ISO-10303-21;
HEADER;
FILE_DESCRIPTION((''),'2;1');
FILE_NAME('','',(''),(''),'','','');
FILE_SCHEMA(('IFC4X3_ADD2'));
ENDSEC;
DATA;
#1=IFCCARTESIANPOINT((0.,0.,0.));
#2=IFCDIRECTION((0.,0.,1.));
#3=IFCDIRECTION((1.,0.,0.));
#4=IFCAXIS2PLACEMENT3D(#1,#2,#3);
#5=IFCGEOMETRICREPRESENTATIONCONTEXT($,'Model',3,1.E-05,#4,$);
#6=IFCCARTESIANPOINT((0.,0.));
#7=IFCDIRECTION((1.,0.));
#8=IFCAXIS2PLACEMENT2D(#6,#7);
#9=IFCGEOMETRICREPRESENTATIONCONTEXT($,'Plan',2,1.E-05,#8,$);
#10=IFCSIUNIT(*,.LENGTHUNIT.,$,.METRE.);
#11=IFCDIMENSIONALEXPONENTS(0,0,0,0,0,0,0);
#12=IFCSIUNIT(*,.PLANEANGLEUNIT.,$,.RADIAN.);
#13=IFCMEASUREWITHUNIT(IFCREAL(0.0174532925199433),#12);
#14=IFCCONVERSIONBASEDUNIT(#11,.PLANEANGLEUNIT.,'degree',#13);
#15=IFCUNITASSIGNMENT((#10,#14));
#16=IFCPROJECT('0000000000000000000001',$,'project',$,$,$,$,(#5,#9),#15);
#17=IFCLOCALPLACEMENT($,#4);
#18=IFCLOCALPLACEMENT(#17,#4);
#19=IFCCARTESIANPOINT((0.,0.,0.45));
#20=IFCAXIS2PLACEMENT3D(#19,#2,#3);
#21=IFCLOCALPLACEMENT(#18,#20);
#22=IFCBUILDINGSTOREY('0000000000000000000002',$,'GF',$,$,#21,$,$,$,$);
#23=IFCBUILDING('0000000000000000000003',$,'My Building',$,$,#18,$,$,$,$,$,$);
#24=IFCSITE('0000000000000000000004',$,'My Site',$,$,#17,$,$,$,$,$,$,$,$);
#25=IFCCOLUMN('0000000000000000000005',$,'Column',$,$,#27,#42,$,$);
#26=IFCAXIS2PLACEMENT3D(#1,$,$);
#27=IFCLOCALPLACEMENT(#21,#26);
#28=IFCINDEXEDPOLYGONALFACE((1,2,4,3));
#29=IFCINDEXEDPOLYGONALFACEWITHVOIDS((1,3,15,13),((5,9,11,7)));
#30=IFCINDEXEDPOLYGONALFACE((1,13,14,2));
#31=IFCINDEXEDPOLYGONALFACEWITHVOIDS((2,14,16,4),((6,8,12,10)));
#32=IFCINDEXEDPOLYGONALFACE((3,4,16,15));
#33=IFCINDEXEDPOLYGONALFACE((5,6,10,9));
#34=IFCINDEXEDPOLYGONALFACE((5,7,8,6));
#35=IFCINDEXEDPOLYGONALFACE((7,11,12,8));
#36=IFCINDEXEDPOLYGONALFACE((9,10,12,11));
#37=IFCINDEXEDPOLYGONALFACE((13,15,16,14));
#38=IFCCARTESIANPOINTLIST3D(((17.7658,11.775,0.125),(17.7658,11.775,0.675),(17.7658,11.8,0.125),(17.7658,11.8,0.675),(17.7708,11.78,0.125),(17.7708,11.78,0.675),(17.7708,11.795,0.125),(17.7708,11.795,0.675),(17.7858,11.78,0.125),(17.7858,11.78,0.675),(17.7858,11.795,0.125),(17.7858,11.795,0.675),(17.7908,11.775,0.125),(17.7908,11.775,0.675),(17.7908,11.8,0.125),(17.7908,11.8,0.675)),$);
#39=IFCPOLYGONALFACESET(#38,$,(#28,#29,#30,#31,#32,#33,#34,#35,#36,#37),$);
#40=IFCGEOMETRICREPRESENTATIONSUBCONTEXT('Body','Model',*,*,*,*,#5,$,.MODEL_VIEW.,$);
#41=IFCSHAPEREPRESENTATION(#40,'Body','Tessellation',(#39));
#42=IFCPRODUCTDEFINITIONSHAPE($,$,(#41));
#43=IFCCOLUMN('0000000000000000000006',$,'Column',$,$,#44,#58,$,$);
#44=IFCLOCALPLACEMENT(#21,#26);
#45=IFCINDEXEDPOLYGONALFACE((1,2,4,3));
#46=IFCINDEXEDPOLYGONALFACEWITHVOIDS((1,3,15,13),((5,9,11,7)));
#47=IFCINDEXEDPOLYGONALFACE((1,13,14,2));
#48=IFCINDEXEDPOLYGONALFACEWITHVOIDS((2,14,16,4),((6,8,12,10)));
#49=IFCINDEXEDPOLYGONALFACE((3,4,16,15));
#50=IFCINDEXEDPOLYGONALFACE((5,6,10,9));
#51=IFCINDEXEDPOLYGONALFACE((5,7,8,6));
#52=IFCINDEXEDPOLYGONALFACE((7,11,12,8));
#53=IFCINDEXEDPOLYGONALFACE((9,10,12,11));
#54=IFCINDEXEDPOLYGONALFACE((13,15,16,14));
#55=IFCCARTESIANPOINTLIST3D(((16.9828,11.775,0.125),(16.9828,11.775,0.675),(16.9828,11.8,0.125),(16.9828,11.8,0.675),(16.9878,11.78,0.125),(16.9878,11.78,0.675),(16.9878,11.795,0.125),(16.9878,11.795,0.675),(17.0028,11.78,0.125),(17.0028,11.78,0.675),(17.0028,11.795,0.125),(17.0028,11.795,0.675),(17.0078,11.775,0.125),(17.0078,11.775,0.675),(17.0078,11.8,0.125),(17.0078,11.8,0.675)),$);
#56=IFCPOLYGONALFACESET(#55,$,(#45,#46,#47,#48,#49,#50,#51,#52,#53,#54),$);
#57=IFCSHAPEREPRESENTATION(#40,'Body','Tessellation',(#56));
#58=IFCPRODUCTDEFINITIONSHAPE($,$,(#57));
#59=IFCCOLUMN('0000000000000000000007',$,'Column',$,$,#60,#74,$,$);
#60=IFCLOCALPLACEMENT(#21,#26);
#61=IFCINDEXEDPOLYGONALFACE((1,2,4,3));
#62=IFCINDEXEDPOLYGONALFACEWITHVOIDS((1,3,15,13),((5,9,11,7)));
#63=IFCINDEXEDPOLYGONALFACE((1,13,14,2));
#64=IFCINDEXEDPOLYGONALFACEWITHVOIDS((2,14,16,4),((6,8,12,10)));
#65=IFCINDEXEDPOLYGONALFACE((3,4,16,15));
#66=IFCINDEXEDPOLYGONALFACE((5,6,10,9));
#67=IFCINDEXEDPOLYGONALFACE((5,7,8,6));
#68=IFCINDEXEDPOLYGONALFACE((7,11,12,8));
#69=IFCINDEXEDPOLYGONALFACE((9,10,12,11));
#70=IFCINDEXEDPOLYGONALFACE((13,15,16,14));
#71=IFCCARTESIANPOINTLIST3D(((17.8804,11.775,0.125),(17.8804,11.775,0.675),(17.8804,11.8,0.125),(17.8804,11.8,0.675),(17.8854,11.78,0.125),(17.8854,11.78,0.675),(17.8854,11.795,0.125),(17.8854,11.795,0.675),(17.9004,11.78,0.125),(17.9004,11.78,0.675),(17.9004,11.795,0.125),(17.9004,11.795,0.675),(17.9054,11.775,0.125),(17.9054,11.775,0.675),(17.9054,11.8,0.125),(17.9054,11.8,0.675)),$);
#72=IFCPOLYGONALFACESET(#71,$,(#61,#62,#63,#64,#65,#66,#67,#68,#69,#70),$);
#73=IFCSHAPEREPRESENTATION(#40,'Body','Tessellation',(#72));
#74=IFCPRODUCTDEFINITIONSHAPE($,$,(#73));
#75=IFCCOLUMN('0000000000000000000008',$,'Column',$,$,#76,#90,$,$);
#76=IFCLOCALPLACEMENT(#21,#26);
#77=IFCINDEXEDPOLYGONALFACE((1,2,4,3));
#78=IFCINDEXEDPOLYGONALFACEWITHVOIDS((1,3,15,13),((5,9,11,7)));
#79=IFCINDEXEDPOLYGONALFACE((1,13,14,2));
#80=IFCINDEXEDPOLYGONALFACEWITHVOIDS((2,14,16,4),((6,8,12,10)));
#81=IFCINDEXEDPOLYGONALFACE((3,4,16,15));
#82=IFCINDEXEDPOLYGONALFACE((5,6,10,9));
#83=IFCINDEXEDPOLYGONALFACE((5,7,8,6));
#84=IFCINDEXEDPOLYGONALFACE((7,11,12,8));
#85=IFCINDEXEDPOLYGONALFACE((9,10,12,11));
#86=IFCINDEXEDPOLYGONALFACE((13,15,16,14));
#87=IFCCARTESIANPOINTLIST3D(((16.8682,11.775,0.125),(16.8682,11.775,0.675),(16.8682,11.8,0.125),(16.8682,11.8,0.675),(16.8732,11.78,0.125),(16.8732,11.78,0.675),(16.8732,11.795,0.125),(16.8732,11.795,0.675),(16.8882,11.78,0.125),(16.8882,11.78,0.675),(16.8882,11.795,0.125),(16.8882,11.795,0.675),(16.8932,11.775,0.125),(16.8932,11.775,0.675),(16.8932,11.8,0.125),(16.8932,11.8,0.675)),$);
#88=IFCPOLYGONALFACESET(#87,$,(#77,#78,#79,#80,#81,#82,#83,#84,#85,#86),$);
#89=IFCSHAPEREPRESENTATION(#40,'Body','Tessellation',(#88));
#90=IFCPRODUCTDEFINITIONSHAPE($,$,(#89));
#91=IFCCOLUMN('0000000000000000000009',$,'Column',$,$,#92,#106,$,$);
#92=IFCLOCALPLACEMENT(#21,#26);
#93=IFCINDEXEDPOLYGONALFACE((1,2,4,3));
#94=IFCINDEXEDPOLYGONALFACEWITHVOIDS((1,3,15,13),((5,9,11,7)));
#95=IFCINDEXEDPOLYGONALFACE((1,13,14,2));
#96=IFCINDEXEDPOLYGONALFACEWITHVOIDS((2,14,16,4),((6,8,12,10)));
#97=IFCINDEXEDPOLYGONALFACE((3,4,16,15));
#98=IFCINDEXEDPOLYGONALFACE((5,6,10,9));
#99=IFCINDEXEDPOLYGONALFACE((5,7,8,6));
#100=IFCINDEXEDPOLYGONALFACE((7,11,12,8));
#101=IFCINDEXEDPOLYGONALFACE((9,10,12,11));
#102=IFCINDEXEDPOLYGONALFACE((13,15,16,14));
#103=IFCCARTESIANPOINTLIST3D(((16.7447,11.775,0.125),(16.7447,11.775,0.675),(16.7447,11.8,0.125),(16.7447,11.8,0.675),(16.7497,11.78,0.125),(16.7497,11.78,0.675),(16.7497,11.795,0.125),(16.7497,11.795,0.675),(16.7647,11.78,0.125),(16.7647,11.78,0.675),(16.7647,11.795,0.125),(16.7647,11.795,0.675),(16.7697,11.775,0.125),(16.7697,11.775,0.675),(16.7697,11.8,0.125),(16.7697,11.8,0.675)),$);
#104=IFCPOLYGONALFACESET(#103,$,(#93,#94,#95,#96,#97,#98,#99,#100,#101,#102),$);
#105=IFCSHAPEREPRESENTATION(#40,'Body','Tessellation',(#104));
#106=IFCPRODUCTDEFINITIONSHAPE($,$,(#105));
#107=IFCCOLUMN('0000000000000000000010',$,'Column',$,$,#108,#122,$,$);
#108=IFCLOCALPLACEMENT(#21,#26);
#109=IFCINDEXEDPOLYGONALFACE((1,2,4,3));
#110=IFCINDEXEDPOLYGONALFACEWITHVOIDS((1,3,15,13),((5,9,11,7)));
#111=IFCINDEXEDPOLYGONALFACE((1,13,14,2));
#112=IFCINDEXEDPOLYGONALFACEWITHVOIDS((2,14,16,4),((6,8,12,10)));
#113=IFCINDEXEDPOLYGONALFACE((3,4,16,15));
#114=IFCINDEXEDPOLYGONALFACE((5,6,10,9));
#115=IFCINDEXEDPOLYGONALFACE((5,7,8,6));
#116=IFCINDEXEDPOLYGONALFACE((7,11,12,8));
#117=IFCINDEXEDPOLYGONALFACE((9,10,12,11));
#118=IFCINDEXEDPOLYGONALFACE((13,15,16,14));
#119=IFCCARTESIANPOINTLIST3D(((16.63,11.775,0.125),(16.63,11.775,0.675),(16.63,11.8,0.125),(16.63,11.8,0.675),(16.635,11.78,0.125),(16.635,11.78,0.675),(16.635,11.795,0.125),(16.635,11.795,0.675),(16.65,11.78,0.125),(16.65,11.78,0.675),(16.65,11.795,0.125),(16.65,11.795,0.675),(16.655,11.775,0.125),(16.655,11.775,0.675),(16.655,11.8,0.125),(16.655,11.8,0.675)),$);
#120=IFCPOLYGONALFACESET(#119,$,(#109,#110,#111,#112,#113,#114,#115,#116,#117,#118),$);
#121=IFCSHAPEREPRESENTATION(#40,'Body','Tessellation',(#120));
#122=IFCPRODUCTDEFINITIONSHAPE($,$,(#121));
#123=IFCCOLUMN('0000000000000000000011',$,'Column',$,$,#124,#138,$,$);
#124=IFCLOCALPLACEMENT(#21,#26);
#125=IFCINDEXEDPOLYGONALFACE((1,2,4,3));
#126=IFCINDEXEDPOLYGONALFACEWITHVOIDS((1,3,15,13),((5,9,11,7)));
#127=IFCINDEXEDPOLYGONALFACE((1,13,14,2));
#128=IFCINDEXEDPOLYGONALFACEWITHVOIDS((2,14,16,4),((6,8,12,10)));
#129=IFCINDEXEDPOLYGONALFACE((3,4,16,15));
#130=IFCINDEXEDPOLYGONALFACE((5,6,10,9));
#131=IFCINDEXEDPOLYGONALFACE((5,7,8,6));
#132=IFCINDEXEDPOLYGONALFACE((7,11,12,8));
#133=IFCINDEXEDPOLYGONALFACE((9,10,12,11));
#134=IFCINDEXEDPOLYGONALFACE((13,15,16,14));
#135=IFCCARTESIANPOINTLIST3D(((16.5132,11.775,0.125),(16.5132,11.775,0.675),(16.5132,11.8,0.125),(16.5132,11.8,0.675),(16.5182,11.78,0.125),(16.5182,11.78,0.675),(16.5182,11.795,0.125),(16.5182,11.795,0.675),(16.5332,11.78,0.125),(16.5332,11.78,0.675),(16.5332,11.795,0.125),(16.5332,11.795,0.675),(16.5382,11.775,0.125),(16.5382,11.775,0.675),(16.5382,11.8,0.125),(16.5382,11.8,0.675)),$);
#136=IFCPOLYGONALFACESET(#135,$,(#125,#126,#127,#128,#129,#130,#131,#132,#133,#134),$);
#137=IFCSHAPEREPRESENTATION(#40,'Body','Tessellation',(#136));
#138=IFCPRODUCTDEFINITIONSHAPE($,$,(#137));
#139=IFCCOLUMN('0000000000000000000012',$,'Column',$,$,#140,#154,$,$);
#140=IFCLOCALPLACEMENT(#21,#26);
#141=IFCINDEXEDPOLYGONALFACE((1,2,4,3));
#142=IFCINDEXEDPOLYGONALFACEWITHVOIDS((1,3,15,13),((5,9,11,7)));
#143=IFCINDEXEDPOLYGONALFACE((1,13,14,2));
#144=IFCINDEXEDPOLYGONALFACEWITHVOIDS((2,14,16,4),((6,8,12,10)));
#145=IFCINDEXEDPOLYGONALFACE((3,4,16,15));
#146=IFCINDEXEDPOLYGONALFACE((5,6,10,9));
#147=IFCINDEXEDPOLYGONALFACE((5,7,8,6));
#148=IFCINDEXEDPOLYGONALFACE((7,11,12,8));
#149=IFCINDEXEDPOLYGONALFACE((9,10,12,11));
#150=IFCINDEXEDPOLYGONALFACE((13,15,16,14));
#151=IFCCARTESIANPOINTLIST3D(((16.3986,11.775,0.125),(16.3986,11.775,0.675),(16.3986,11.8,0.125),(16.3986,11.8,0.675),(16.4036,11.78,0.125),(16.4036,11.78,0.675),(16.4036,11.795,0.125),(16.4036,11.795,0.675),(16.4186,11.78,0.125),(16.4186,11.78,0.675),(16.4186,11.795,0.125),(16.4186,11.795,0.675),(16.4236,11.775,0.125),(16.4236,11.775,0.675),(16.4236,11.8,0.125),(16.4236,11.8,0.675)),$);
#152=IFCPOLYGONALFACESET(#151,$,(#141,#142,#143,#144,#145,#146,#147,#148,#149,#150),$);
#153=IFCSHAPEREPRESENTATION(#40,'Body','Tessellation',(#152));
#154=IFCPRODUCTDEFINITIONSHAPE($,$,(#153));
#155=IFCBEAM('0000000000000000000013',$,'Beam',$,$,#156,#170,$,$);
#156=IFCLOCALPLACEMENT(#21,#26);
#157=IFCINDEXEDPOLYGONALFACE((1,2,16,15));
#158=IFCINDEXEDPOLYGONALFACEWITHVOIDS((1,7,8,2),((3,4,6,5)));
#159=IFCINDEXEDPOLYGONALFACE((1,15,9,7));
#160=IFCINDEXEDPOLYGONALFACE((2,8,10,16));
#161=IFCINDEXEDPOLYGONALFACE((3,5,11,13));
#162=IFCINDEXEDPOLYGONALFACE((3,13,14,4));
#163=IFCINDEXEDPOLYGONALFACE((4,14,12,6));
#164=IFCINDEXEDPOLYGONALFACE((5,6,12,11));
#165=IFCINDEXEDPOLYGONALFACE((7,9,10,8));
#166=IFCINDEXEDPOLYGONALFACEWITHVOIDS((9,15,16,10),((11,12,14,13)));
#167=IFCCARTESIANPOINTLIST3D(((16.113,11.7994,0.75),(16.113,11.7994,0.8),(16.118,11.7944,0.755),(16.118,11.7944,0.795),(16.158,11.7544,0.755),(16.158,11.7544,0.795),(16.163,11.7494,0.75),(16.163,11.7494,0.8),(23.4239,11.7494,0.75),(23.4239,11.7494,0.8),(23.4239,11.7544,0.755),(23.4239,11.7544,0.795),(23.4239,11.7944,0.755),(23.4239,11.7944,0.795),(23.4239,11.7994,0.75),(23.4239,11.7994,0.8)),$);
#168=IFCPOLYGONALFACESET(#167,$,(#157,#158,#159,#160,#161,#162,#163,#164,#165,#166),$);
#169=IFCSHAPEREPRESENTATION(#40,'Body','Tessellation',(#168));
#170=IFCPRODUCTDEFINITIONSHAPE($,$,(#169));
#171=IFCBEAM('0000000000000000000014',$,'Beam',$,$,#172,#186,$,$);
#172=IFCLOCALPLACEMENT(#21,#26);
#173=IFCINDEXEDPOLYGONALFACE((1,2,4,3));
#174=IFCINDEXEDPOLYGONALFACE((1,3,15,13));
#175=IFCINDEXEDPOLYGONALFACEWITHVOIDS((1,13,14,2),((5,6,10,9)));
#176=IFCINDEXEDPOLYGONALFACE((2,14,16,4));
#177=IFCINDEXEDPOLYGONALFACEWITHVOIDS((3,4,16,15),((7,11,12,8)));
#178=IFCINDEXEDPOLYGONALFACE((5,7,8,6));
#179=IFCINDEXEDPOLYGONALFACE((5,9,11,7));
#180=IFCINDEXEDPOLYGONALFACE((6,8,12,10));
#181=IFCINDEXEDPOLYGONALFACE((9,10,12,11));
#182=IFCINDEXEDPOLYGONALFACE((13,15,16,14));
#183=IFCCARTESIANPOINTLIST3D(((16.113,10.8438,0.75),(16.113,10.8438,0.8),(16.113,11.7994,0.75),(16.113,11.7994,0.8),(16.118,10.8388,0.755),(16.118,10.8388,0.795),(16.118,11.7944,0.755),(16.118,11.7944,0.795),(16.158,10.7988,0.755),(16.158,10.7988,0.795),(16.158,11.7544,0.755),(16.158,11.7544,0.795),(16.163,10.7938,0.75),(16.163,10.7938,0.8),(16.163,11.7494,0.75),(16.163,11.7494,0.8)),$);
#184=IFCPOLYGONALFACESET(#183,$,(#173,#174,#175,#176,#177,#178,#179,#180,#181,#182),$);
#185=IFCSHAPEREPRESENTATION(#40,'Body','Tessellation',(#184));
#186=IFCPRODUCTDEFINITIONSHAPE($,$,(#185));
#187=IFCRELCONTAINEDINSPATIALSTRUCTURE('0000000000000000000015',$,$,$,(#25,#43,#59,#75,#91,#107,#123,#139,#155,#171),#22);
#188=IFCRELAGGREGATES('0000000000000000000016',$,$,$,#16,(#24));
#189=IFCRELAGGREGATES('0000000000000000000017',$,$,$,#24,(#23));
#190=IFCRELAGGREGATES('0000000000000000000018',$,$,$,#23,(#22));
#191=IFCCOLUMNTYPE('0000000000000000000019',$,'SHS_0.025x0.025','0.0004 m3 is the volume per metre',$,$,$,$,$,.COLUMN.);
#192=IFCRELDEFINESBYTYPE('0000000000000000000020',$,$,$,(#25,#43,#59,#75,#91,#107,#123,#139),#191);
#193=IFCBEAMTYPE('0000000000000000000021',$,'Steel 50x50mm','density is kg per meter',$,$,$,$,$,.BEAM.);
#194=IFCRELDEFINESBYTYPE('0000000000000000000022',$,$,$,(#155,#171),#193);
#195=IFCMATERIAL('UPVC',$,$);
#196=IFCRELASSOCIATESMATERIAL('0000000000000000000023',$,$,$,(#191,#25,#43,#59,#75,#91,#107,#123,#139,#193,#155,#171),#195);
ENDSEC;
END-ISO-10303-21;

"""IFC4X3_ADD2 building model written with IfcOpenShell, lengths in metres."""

from ifc_helpers import new_model, entity, si_unit, converted_unit, frame, origin_with_axes, origin_2d_with_axis, place, context, subcontext, project, spatial, hollow_rectangle, extrude, clip, halfspace, material, material_profile, profile_set, profile_usage, type_object, element, save


model = new_model("IFC4X3_ADD2")

# Units and contexts
model_context = context("Model", 3, precision=1e-05, world=origin_with_axes())
plan_context = context("Plan", 2, precision=1e-05, world=origin_2d_with_axis())
body_context = subcontext(model_context, "Body", "Model", "MODEL_VIEW")
ifc_project = project(units=[si_unit("LENGTHUNIT", "METRE"), converted_unit("PLANEANGLEUNIT", "degree", entity("IfcReal", 0.0174532925199433), si_unit("PLANEANGLEUNIT", "RADIAN"), dimensions=[0, 0, 0, 0, 0, 0, 0])], contexts=[model_context, plan_context])

# Site, building, storey
site_placement = place(None, origin_with_axes())
site = spatial("IfcSite", under=ifc_project, at=site_placement, Name="My Site")
building_placement = place(site_placement, origin_with_axes())
building = spatial("IfcBuilding", under=site, at=building_placement, Name="My Building")
storey_placement = place(building_placement, frame((0.0, 0.0, 0.45), z_axis=(0.0, 0.0, 1.0), x_axis=(1.0, 0.0, 0.0)))
storey = spatial("IfcBuildingStorey", under=building, at=storey_placement, Name="GF")

# Columns
ifc_material = material(Name="UPVC")
ifc_material_profile_1 = material_profile(ifc_material, hollow_rectangle(XDim=0.025, YDim=0.025, WallThickness=0.005))
ifc_profile_set_1 = profile_set([ifc_material_profile_1])
column_type_1 = type_object("IfcColumnType", Name="SHS_0.025x0.025", Description="0.0004 m3 is the volume per metre", PredefinedType="COLUMN", material=ifc_profile_set_1)
ifc_profile_usage_1 = profile_usage(ifc_profile_set_1, cardinal=5)
column_1_placement = place(storey_placement, frame((17.7783, 11.7875, 0.125), z_axis=(0.0, 0.0, 1.0), x_axis=(1.0, 0.0, 0.0)))
element("IfcColumn", 1, at=column_1_placement, inside=storey, type_object=column_type_1, material=ifc_profile_usage_1, Name="Column", context=body_context, shape_type="SweptSolid", body=[
    extrude(hollow_rectangle(XDim=0.025, YDim=0.025, WallThickness=0.005), origin_with_axes(), (0.0, 0.0, 1.0), 0.55),
])
ifc_profile_usage_2 = profile_usage(ifc_profile_set_1, cardinal=5)
column_2_placement = place(storey_placement, frame((16.9953, 11.7875, 0.125), z_axis=(0.0, 0.0, 1.0), x_axis=(1.0, 0.0, 0.0)))
element("IfcColumn", 2, at=column_2_placement, inside=storey, type_object=column_type_1, material=ifc_profile_usage_2, Name="Column", context=body_context, shape_type="SweptSolid", body=[
    extrude(hollow_rectangle(XDim=0.025, YDim=0.025, WallThickness=0.005), origin_with_axes(), (0.0, 0.0, 1.0), 0.55),
])
ifc_profile_usage_3 = profile_usage(ifc_profile_set_1, cardinal=5)
column_3_placement = place(storey_placement, frame((17.8929, 11.7875, 0.125), z_axis=(0.0, 0.0, 1.0), x_axis=(1.0, 0.0, 0.0)))
element("IfcColumn", 3, at=column_3_placement, inside=storey, type_object=column_type_1, material=ifc_profile_usage_3, Name="Column", context=body_context, shape_type="SweptSolid", body=[
    extrude(hollow_rectangle(XDim=0.025, YDim=0.025, WallThickness=0.005), origin_with_axes(), (0.0, 0.0, 1.0), 0.55),
])
ifc_profile_usage_4 = profile_usage(ifc_profile_set_1, cardinal=5)
column_4_placement = place(storey_placement, frame((16.8807, 11.7875, 0.125), z_axis=(0.0, 0.0, 1.0), x_axis=(1.0, 0.0, 0.0)))
element("IfcColumn", 4, at=column_4_placement, inside=storey, type_object=column_type_1, material=ifc_profile_usage_4, Name="Column", context=body_context, shape_type="SweptSolid", body=[
    extrude(hollow_rectangle(XDim=0.025, YDim=0.025, WallThickness=0.005), origin_with_axes(), (0.0, 0.0, 1.0), 0.55),
])
ifc_profile_usage_5 = profile_usage(ifc_profile_set_1, cardinal=5)
column_5_placement = place(storey_placement, frame((16.7572, 11.7875, 0.125), z_axis=(0.0, 0.0, 1.0), x_axis=(1.0, 0.0, 0.0)))
element("IfcColumn", 5, at=column_5_placement, inside=storey, type_object=column_type_1, material=ifc_profile_usage_5, Name="Column", context=body_context, shape_type="SweptSolid", body=[
    extrude(hollow_rectangle(XDim=0.025, YDim=0.025, WallThickness=0.005), origin_with_axes(), (0.0, 0.0, 1.0), 0.55),
])
ifc_profile_usage_6 = profile_usage(ifc_profile_set_1, cardinal=5)
column_6_placement = place(storey_placement, frame((16.6425, 11.7875, 0.125), z_axis=(0.0, 0.0, 1.0), x_axis=(1.0, 0.0, 0.0)))
element("IfcColumn", 6, at=column_6_placement, inside=storey, type_object=column_type_1, material=ifc_profile_usage_6, Name="Column", context=body_context, shape_type="SweptSolid", body=[
    extrude(hollow_rectangle(XDim=0.025, YDim=0.025, WallThickness=0.005), origin_with_axes(), (0.0, 0.0, 1.0), 0.55),
])
ifc_profile_usage_7 = profile_usage(ifc_profile_set_1, cardinal=5)
column_7_placement = place(storey_placement, frame((16.5257, 11.7875, 0.125), z_axis=(0.0, 0.0, 1.0), x_axis=(1.0, 0.0, 0.0)))
element("IfcColumn", 7, at=column_7_placement, inside=storey, type_object=column_type_1, material=ifc_profile_usage_7, Name="Column", context=body_context, shape_type="SweptSolid", body=[
    extrude(hollow_rectangle(XDim=0.025, YDim=0.025, WallThickness=0.005), origin_with_axes(), (0.0, 0.0, 1.0), 0.55),
])
ifc_profile_usage_8 = profile_usage(ifc_profile_set_1, cardinal=5)
column_8_placement = place(storey_placement, frame((16.4111, 11.7875, 0.125), z_axis=(0.0, 0.0, 1.0), x_axis=(1.0, 0.0, 0.0)))
element("IfcColumn", 8, at=column_8_placement, inside=storey, type_object=column_type_1, material=ifc_profile_usage_8, Name="Column", context=body_context, shape_type="SweptSolid", body=[
    extrude(hollow_rectangle(XDim=0.025, YDim=0.025, WallThickness=0.005), origin_with_axes(), (0.0, 0.0, 1.0), 0.55),
])

# Beams
ifc_material_profile_2 = material_profile(ifc_material, hollow_rectangle(XDim=0.05, YDim=0.05, WallThickness=0.005))
ifc_profile_set_2 = profile_set([ifc_material_profile_2])
ifc_profile_usage_9 = profile_usage(ifc_profile_set_2)
beam_type_1 = type_object("IfcBeamType", Name="Steel 50x50mm", Description="density is kg per meter", PredefinedType="BEAM", material=ifc_profile_set_2)
beam_1_placement = place(storey_placement, frame((16.113, 11.7744, 0.775), z_axis=(1.0, 0.0, 0.0), x_axis=(0.0, 1.0, 0.0)))
element("IfcBeam", 9, at=beam_1_placement, inside=storey, type_object=beam_type_1, material=ifc_profile_usage_9, Name="Beam", context=body_context, shape_type="Clipping", body=[
    clip(extrude(hollow_rectangle(XDim=0.05, YDim=0.05, WallThickness=0.005), origin_with_axes(), (0.0, 0.0, 1.0), 7.3109), halfspace(frame((0.025, -1.225, 0.0), z_axis=(-0.707107, 0.0, -0.707107), x_axis=(0.0, 1.0, 0.0)), False)),
])
ifc_profile_usage_10 = profile_usage(ifc_profile_set_2)
beam_2_placement = place(storey_placement, frame((16.138, 10.7938, 0.775), z_axis=(0.0, 1.0, 0.0), x_axis=(-1.0, 0.0, 0.0)))
element("IfcBeam", 10, at=beam_2_placement, inside=storey, type_object=beam_type_1, material=ifc_profile_usage_10, Name="Beam", context=body_context, shape_type="Clipping", body=[
    clip(clip(extrude(hollow_rectangle(XDim=0.05, YDim=0.05, WallThickness=0.005), origin_with_axes(), (0.0, 0.0, 1.0), 1.0055), halfspace(frame((0.025, -1.225, 1.0055), z_axis=(-0.707107, 0.0, 0.707107), x_axis=(0.0, 1.0, 0.0)), False)), halfspace(frame((-0.025, -1.225, 0.0), z_axis=(0.707107, 0.0, -0.707107), x_axis=(0.0, -1.0, 0.0)), False)),
])

save(model, "model.ifc")
